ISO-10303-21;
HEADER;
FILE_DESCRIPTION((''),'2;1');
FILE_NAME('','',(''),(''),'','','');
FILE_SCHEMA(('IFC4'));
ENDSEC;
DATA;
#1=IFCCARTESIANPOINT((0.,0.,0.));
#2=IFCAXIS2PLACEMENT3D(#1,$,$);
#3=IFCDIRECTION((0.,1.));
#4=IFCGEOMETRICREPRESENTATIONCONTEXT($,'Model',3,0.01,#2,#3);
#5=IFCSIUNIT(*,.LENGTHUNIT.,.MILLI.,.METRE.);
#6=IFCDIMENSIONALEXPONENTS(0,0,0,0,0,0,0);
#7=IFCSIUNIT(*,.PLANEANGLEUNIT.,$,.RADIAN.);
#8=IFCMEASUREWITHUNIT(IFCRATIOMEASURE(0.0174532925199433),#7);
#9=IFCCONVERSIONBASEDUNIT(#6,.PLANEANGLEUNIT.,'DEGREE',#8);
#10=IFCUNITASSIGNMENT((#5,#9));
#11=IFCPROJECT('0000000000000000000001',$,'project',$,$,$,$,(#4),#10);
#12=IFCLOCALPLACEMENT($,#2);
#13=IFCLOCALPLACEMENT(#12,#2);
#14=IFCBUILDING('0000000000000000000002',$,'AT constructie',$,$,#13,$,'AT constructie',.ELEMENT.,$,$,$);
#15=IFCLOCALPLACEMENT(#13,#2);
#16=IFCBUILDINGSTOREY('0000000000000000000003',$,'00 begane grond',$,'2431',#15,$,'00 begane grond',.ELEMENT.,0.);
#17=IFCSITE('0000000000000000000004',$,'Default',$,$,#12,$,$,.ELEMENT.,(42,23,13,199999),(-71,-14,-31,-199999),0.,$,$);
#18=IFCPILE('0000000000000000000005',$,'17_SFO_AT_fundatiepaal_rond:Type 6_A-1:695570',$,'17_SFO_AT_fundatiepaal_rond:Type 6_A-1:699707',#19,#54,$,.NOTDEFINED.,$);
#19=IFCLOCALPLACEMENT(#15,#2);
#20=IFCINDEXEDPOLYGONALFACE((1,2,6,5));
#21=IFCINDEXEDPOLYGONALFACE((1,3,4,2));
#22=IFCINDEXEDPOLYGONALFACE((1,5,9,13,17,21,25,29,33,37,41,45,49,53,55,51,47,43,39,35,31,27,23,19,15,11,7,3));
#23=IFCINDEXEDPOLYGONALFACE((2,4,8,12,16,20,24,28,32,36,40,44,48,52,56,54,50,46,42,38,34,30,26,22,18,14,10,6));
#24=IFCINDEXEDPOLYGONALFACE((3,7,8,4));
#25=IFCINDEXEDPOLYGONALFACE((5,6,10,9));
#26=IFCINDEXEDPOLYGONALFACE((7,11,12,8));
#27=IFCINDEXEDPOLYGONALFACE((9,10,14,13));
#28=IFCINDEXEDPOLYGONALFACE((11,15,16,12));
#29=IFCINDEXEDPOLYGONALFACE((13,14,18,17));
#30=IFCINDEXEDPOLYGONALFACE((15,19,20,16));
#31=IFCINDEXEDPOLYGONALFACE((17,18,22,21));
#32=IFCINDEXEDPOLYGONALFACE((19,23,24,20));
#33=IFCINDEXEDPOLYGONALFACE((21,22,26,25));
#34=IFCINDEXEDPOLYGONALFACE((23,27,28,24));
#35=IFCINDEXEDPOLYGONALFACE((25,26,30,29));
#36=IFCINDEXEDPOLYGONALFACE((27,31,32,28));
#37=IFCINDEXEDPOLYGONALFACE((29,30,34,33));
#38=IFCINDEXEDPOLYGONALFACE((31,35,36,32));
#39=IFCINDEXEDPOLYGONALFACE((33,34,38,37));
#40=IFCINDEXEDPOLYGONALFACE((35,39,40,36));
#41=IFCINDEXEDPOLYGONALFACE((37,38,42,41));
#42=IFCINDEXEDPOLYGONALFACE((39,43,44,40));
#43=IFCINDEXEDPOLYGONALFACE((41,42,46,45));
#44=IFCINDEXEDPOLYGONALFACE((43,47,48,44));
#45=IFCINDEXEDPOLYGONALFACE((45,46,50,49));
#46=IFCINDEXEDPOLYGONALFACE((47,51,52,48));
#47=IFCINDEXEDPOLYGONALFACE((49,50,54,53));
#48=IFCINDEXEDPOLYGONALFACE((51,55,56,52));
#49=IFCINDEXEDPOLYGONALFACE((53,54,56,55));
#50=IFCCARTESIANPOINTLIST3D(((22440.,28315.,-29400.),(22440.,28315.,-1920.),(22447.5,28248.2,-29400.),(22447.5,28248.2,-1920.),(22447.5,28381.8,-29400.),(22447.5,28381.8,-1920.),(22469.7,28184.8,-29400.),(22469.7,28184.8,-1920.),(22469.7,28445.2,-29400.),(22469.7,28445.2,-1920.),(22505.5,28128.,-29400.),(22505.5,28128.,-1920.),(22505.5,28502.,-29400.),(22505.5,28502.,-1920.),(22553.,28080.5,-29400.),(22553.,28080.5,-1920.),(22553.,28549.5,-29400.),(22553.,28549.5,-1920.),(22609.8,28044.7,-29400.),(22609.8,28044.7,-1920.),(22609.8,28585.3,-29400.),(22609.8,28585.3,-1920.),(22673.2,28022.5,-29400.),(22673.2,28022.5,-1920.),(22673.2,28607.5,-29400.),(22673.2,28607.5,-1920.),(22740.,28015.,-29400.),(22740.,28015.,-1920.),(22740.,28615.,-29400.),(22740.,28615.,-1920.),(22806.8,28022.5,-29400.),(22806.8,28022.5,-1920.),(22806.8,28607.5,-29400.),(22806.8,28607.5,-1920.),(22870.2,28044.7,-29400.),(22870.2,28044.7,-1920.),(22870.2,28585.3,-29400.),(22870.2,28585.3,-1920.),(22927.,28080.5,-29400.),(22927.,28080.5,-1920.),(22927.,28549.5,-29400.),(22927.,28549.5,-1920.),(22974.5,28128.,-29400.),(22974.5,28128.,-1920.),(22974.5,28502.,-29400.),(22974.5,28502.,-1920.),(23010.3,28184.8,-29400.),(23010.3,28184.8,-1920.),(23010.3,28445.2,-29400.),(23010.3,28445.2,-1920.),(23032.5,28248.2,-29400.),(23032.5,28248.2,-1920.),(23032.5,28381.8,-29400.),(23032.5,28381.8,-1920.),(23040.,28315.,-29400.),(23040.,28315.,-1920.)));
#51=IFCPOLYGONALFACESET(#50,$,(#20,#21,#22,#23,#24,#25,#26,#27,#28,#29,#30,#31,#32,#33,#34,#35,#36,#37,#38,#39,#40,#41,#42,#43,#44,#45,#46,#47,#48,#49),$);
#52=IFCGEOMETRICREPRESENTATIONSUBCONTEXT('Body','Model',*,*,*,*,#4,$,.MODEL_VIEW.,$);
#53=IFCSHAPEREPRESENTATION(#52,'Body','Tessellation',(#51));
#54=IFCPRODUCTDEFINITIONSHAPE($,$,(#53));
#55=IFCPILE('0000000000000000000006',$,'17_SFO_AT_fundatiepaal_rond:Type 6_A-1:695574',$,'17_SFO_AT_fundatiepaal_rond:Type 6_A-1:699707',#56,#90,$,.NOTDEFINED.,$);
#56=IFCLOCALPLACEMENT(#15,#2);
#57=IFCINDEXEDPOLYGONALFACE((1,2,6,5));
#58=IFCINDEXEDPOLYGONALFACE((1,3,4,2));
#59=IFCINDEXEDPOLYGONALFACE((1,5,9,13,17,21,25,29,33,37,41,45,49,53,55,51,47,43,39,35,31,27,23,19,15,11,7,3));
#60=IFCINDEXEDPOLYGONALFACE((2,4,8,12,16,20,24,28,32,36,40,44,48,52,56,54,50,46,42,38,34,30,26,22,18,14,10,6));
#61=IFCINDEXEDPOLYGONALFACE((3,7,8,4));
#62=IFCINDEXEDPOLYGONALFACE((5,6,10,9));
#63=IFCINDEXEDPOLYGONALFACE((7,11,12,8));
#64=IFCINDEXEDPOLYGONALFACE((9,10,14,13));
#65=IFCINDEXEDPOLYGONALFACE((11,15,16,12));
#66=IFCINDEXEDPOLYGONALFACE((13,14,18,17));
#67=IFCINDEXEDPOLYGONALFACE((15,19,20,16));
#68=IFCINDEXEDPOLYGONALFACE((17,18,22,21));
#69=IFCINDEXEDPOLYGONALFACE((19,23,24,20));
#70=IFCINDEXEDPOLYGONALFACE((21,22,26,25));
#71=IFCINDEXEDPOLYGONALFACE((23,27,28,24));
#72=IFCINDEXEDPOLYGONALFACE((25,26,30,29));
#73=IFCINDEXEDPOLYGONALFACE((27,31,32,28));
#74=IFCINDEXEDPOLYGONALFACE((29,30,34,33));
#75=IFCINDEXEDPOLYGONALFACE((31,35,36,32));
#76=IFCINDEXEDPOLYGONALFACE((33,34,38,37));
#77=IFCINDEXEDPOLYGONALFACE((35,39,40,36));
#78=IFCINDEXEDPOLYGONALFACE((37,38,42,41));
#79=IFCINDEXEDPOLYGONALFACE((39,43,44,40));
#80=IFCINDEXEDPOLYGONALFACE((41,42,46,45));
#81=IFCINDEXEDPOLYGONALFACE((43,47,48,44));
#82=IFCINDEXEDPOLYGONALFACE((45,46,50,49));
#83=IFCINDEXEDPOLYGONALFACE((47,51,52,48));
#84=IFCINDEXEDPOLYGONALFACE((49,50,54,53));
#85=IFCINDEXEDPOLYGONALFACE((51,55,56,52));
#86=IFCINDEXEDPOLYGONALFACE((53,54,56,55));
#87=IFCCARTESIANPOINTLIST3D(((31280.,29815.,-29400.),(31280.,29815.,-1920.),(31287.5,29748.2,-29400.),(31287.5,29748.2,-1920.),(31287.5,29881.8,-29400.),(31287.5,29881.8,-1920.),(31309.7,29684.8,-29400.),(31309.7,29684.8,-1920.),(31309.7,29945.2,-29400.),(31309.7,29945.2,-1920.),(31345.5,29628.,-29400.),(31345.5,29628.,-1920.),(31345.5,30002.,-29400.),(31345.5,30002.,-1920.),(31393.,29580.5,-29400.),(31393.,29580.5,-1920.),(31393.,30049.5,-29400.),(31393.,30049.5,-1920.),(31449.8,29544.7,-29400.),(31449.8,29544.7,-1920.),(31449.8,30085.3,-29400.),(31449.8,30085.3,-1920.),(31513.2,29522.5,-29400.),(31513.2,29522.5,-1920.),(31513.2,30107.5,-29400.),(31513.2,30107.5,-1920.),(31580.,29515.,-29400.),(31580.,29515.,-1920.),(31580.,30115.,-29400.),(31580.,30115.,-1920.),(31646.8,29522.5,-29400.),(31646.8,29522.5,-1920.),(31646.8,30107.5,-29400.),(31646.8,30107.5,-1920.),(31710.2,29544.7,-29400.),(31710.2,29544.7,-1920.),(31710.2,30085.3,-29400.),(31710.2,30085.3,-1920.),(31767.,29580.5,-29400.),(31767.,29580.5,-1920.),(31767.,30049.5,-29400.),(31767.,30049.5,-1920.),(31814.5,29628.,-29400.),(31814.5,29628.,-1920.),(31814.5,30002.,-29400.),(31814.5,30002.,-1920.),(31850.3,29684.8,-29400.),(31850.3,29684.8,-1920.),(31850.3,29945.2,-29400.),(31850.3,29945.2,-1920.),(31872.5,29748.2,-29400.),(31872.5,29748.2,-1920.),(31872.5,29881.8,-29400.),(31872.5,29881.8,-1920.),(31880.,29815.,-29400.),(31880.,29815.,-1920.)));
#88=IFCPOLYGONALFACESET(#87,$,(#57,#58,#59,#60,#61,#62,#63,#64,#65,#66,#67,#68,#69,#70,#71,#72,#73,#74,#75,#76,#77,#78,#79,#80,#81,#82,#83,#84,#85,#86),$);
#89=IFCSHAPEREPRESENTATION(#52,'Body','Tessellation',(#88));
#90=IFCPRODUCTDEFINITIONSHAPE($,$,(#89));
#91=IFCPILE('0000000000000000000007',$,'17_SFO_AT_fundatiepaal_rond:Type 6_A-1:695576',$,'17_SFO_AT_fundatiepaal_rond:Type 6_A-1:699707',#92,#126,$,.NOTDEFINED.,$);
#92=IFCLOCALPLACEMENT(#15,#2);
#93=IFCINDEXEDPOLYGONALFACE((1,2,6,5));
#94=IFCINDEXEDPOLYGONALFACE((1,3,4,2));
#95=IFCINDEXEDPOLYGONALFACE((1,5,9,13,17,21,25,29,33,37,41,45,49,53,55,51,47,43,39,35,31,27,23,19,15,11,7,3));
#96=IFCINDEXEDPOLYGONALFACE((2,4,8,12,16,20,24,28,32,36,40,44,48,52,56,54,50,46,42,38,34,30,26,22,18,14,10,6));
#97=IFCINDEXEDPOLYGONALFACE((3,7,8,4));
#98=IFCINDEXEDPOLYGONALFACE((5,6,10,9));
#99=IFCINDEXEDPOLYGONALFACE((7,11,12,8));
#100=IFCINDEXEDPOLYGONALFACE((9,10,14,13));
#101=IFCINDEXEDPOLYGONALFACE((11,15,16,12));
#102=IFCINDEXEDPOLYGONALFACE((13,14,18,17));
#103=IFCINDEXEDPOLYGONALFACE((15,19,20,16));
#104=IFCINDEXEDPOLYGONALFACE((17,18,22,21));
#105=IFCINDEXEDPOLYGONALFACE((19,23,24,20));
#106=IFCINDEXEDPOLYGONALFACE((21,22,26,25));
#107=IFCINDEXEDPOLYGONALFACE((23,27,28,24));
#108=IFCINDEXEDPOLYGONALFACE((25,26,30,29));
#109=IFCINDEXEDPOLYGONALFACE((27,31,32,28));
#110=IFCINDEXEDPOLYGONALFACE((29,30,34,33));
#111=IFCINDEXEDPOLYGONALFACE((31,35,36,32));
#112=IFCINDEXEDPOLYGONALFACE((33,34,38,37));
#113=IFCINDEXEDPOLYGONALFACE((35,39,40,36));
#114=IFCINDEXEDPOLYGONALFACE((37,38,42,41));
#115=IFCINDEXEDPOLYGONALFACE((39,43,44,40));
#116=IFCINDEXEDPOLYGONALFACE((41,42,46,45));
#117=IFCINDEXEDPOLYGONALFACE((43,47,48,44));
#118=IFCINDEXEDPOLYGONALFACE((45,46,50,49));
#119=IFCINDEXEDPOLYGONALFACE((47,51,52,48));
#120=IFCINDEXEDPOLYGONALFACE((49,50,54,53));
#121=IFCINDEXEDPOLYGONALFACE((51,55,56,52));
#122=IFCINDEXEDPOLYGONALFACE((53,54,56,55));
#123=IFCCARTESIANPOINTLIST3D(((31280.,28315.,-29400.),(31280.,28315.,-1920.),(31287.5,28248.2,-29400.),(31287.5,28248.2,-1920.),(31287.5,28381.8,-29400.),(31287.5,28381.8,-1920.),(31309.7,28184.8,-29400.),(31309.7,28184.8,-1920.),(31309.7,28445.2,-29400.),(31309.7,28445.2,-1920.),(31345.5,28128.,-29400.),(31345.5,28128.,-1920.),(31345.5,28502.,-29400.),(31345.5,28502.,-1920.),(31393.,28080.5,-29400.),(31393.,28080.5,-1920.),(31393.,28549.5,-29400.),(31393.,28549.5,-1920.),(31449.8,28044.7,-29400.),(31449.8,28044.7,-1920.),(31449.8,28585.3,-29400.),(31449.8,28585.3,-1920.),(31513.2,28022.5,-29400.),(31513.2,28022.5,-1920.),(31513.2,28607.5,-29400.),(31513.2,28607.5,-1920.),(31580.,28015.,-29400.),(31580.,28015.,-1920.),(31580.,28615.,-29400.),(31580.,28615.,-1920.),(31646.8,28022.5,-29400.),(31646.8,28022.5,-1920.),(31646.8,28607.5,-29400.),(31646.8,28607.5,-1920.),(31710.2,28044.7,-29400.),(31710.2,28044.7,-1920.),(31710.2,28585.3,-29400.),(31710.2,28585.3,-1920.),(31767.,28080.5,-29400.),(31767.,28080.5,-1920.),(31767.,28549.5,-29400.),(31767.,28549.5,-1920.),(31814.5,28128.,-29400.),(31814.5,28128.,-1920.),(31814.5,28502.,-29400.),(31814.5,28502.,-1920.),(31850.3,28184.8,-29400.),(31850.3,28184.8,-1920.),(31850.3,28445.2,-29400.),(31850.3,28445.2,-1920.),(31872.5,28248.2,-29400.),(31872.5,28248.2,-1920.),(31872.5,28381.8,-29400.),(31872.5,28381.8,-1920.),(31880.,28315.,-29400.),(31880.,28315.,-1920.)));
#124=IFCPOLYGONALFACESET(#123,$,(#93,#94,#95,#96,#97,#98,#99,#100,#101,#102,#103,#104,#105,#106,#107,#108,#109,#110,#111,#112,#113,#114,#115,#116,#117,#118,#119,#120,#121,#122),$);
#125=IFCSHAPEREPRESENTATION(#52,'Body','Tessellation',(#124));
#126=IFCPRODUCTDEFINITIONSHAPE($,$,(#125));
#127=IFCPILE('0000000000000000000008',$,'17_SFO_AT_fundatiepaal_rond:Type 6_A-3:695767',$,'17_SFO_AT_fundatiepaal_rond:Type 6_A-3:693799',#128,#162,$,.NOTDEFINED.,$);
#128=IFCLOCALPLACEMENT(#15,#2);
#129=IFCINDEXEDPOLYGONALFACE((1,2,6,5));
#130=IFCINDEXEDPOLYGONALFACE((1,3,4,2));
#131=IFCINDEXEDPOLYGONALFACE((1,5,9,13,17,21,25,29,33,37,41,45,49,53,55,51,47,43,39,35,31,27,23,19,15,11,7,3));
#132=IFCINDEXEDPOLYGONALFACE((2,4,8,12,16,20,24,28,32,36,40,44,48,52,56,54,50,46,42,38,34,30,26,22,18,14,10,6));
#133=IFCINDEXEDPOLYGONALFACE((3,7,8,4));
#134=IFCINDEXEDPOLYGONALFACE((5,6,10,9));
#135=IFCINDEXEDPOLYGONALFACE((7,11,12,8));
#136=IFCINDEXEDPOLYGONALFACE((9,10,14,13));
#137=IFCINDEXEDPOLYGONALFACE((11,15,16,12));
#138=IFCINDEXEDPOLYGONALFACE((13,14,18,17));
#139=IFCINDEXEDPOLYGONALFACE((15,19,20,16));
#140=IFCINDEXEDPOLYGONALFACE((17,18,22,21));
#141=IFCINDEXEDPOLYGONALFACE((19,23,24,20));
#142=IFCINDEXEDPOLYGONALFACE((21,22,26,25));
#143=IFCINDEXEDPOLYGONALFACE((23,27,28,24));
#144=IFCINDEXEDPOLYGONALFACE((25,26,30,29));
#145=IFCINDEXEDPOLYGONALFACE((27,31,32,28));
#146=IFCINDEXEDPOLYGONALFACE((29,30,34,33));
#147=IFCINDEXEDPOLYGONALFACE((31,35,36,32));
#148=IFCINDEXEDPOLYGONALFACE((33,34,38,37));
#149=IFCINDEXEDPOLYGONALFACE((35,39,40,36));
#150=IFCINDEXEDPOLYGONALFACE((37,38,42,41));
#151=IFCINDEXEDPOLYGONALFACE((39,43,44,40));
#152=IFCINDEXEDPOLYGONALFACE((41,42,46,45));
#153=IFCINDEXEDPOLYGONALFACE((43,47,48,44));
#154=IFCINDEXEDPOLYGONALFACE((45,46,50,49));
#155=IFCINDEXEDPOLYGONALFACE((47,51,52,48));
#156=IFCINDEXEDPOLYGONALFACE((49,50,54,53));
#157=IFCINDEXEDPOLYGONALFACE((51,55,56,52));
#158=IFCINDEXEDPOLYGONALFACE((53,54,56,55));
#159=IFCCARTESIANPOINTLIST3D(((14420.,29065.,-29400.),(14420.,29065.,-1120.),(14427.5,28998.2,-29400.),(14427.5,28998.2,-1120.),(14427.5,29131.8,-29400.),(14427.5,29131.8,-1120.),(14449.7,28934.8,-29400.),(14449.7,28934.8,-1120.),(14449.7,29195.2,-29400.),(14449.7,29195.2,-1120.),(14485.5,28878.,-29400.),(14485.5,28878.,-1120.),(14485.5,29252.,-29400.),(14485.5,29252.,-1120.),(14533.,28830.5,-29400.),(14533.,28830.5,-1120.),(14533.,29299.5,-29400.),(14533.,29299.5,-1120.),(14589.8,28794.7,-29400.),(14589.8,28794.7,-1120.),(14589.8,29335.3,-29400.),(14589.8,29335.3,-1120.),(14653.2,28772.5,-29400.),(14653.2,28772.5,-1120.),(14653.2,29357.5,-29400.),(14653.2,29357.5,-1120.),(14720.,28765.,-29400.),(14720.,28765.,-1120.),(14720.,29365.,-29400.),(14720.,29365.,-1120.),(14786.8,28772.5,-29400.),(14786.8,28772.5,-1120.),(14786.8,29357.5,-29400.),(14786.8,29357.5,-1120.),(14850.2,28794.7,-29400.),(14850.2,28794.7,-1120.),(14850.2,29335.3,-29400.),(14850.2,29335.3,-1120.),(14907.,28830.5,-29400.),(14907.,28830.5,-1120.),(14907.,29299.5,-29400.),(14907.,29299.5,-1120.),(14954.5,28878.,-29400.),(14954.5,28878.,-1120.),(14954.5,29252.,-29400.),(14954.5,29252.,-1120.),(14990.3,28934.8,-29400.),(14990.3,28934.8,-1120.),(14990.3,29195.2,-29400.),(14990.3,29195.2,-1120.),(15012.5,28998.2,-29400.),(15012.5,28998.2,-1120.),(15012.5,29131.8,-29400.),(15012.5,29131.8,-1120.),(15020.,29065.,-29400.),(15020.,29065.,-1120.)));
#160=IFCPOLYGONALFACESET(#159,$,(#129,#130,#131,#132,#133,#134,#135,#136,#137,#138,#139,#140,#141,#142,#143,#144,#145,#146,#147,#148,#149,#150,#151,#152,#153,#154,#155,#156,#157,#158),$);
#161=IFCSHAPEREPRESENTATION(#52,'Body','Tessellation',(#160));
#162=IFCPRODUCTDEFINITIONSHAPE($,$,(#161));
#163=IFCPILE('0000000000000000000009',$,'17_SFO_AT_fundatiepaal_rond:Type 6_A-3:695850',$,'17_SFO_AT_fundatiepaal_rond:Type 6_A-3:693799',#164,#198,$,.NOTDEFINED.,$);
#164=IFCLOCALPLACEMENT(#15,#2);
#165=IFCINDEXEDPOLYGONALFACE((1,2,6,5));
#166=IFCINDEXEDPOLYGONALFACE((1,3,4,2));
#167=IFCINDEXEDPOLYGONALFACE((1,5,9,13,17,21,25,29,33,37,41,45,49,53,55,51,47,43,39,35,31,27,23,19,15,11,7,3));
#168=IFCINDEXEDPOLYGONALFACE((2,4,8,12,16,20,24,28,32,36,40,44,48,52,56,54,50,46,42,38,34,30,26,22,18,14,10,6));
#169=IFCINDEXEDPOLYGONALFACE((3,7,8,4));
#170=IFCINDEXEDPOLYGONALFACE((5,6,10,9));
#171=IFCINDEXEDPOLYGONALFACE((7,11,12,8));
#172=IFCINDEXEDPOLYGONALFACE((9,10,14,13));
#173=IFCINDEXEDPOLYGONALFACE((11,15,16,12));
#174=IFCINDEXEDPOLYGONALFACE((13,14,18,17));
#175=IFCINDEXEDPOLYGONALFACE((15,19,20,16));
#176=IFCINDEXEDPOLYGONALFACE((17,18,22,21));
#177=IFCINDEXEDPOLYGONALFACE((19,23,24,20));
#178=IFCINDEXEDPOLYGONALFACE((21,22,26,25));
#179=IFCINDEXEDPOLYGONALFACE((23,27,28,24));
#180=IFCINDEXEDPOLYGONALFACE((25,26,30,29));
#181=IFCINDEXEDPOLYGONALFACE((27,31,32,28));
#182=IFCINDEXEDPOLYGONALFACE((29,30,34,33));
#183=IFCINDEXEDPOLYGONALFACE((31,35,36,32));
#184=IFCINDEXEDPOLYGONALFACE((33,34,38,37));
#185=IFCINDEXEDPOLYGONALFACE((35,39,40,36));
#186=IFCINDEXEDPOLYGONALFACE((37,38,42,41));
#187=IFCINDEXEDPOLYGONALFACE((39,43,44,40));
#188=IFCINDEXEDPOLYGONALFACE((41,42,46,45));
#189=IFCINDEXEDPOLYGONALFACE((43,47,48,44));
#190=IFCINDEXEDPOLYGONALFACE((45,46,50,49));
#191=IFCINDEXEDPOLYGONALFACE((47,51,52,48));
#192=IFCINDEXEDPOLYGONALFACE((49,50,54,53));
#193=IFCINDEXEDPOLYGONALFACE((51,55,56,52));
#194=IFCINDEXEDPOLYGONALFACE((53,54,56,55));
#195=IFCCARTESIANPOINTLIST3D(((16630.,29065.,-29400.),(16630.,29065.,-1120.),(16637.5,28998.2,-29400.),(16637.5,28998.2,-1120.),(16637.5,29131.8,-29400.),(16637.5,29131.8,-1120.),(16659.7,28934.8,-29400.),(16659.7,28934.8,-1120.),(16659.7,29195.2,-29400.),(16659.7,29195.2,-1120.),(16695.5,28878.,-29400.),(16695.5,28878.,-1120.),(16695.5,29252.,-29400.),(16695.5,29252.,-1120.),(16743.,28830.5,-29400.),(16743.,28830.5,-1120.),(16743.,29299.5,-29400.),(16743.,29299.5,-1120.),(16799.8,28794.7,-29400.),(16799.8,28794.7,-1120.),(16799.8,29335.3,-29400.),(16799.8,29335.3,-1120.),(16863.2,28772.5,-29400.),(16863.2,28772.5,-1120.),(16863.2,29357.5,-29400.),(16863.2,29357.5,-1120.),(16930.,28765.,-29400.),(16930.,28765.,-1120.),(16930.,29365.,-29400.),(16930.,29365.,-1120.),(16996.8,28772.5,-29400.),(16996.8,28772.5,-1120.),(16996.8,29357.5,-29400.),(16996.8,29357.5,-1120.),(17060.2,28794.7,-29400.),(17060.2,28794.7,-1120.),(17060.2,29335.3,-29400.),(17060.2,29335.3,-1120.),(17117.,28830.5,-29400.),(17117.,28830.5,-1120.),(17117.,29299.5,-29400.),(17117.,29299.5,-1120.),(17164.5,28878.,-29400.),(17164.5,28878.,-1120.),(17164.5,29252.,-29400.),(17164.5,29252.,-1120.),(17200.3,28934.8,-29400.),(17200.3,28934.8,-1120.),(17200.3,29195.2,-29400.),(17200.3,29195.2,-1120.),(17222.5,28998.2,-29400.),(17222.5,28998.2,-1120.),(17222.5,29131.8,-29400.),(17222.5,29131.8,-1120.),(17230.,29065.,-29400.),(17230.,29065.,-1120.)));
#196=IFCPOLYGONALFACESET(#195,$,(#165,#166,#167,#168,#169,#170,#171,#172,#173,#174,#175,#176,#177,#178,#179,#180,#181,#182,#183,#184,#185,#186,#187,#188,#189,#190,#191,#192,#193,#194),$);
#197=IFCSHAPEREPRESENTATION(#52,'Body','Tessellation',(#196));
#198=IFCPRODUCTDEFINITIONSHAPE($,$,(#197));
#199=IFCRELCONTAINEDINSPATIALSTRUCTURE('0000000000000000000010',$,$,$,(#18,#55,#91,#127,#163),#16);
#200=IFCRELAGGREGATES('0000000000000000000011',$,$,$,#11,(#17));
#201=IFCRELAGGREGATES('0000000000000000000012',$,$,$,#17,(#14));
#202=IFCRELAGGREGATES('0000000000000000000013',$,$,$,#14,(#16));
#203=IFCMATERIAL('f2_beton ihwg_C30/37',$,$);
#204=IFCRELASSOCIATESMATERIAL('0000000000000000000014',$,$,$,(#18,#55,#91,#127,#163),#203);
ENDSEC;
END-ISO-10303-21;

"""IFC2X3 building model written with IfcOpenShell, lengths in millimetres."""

from ifc_helpers import new_model, entity, si_unit, converted_unit, direction, frame, origin, origin_2d_with_axis, place, context, subcontext, project, spatial, circle, extrude, material, element, save


model = new_model("IFC2X3")

# Units and contexts
model_context = context("Model", 3, precision=0.01, world=origin(), true_north=direction((0.0, 1.0)))
body_context = subcontext(model_context, "Body", "Model", "MODEL_VIEW")
ifc_project = project(units=[si_unit("LENGTHUNIT", "METRE", prefix="MILLI"), converted_unit("PLANEANGLEUNIT", "DEGREE", entity("IfcRatioMeasure", 0.0174532925199433), si_unit("PLANEANGLEUNIT", "RADIAN"), dimensions=[0, 0, 0, 0, 0, 0, 0])], contexts=[model_context])

# Site, building, storey
site_placement = place(None, origin())
site = spatial("IfcSite", under=ifc_project, at=site_placement, Name="Default", CompositionType="ELEMENT", RefLatitude=(42, 23, 13, 199999), RefLongitude=(-71, -14, -31, -199999), RefElevation=0.0)
building_placement = place(site_placement, origin())
building = spatial("IfcBuilding", under=site, at=building_placement, Name="AT constructie", LongName="AT constructie", CompositionType="ELEMENT")
storey_placement = place(building_placement, origin())
storey = spatial("IfcBuildingStorey", under=building, at=storey_placement, Name="00 begane grond", ObjectType="2431", LongName="00 begane grond", CompositionType="ELEMENT", Elevation=0.0)

# Shared definitions
ifc_material = material(Name="f2_beton ihwg_C30/37")

# Piles
pile_1_placement = place(storey_placement, origin())
element("IfcPile", 1, at=pile_1_placement, inside=storey, material=ifc_material, Name="17_SFO_AT_fundatiepaal_rond:Type 6_A-1:695570", ObjectType="17_SFO_AT_fundatiepaal_rond:Type 6_A-1:699707", PredefinedType="NOTDEFINED", context=body_context, shape_type="SweptSolid", body=[
    extrude(circle(Radius=300.0, at=origin_2d_with_axis()), frame((22740.0, 28315.0, -29400.0)), (0.0, 0.0, 1.0), 27480.0),
])
pile_2_placement = place(storey_placement, origin())
element("IfcPile", 2, at=pile_2_placement, inside=storey, material=ifc_material, Name="17_SFO_AT_fundatiepaal_rond:Type 6_A-1:695574", ObjectType="17_SFO_AT_fundatiepaal_rond:Type 6_A-1:699707", PredefinedType="NOTDEFINED", context=body_context, shape_type="SweptSolid", body=[
    extrude(circle(Radius=300.0, at=origin_2d_with_axis()), frame((31580.0, 29815.0, -29400.0)), (0.0, 0.0, 1.0), 27480.0),
])
pile_3_placement = place(storey_placement, origin())
element("IfcPile", 3, at=pile_3_placement, inside=storey, material=ifc_material, Name="17_SFO_AT_fundatiepaal_rond:Type 6_A-1:695576", ObjectType="17_SFO_AT_fundatiepaal_rond:Type 6_A-1:699707", PredefinedType="NOTDEFINED", context=body_context, shape_type="SweptSolid", body=[
    extrude(circle(Radius=300.0, at=origin_2d_with_axis()), frame((31580.0, 28315.0, -29400.0)), (0.0, 0.0, 1.0), 27480.0),
])
pile_4_placement = place(storey_placement, origin())
element("IfcPile", 4, at=pile_4_placement, inside=storey, material=ifc_material, Name="17_SFO_AT_fundatiepaal_rond:Type 6_A-3:695767", ObjectType="17_SFO_AT_fundatiepaal_rond:Type 6_A-3:693799", PredefinedType="NOTDEFINED", context=body_context, shape_type="SweptSolid", body=[
    extrude(circle(Radius=300.0, at=origin_2d_with_axis()), frame((14720.0, 29065.0, -29400.0)), (0.0, 0.0, 1.0), 28280.0),
])
pile_5_placement = place(storey_placement, origin())
element("IfcPile", 5, at=pile_5_placement, inside=storey, material=ifc_material, Name="17_SFO_AT_fundatiepaal_rond:Type 6_A-3:695850", ObjectType="17_SFO_AT_fundatiepaal_rond:Type 6_A-3:693799", PredefinedType="NOTDEFINED", context=body_context, shape_type="SweptSolid", body=[
    extrude(circle(Radius=300.0, at=origin_2d_with_axis()), frame((16930.0, 29065.0, -29400.0)), (0.0, 0.0, 1.0), 28280.0),
])

save(model, "model.ifc")
